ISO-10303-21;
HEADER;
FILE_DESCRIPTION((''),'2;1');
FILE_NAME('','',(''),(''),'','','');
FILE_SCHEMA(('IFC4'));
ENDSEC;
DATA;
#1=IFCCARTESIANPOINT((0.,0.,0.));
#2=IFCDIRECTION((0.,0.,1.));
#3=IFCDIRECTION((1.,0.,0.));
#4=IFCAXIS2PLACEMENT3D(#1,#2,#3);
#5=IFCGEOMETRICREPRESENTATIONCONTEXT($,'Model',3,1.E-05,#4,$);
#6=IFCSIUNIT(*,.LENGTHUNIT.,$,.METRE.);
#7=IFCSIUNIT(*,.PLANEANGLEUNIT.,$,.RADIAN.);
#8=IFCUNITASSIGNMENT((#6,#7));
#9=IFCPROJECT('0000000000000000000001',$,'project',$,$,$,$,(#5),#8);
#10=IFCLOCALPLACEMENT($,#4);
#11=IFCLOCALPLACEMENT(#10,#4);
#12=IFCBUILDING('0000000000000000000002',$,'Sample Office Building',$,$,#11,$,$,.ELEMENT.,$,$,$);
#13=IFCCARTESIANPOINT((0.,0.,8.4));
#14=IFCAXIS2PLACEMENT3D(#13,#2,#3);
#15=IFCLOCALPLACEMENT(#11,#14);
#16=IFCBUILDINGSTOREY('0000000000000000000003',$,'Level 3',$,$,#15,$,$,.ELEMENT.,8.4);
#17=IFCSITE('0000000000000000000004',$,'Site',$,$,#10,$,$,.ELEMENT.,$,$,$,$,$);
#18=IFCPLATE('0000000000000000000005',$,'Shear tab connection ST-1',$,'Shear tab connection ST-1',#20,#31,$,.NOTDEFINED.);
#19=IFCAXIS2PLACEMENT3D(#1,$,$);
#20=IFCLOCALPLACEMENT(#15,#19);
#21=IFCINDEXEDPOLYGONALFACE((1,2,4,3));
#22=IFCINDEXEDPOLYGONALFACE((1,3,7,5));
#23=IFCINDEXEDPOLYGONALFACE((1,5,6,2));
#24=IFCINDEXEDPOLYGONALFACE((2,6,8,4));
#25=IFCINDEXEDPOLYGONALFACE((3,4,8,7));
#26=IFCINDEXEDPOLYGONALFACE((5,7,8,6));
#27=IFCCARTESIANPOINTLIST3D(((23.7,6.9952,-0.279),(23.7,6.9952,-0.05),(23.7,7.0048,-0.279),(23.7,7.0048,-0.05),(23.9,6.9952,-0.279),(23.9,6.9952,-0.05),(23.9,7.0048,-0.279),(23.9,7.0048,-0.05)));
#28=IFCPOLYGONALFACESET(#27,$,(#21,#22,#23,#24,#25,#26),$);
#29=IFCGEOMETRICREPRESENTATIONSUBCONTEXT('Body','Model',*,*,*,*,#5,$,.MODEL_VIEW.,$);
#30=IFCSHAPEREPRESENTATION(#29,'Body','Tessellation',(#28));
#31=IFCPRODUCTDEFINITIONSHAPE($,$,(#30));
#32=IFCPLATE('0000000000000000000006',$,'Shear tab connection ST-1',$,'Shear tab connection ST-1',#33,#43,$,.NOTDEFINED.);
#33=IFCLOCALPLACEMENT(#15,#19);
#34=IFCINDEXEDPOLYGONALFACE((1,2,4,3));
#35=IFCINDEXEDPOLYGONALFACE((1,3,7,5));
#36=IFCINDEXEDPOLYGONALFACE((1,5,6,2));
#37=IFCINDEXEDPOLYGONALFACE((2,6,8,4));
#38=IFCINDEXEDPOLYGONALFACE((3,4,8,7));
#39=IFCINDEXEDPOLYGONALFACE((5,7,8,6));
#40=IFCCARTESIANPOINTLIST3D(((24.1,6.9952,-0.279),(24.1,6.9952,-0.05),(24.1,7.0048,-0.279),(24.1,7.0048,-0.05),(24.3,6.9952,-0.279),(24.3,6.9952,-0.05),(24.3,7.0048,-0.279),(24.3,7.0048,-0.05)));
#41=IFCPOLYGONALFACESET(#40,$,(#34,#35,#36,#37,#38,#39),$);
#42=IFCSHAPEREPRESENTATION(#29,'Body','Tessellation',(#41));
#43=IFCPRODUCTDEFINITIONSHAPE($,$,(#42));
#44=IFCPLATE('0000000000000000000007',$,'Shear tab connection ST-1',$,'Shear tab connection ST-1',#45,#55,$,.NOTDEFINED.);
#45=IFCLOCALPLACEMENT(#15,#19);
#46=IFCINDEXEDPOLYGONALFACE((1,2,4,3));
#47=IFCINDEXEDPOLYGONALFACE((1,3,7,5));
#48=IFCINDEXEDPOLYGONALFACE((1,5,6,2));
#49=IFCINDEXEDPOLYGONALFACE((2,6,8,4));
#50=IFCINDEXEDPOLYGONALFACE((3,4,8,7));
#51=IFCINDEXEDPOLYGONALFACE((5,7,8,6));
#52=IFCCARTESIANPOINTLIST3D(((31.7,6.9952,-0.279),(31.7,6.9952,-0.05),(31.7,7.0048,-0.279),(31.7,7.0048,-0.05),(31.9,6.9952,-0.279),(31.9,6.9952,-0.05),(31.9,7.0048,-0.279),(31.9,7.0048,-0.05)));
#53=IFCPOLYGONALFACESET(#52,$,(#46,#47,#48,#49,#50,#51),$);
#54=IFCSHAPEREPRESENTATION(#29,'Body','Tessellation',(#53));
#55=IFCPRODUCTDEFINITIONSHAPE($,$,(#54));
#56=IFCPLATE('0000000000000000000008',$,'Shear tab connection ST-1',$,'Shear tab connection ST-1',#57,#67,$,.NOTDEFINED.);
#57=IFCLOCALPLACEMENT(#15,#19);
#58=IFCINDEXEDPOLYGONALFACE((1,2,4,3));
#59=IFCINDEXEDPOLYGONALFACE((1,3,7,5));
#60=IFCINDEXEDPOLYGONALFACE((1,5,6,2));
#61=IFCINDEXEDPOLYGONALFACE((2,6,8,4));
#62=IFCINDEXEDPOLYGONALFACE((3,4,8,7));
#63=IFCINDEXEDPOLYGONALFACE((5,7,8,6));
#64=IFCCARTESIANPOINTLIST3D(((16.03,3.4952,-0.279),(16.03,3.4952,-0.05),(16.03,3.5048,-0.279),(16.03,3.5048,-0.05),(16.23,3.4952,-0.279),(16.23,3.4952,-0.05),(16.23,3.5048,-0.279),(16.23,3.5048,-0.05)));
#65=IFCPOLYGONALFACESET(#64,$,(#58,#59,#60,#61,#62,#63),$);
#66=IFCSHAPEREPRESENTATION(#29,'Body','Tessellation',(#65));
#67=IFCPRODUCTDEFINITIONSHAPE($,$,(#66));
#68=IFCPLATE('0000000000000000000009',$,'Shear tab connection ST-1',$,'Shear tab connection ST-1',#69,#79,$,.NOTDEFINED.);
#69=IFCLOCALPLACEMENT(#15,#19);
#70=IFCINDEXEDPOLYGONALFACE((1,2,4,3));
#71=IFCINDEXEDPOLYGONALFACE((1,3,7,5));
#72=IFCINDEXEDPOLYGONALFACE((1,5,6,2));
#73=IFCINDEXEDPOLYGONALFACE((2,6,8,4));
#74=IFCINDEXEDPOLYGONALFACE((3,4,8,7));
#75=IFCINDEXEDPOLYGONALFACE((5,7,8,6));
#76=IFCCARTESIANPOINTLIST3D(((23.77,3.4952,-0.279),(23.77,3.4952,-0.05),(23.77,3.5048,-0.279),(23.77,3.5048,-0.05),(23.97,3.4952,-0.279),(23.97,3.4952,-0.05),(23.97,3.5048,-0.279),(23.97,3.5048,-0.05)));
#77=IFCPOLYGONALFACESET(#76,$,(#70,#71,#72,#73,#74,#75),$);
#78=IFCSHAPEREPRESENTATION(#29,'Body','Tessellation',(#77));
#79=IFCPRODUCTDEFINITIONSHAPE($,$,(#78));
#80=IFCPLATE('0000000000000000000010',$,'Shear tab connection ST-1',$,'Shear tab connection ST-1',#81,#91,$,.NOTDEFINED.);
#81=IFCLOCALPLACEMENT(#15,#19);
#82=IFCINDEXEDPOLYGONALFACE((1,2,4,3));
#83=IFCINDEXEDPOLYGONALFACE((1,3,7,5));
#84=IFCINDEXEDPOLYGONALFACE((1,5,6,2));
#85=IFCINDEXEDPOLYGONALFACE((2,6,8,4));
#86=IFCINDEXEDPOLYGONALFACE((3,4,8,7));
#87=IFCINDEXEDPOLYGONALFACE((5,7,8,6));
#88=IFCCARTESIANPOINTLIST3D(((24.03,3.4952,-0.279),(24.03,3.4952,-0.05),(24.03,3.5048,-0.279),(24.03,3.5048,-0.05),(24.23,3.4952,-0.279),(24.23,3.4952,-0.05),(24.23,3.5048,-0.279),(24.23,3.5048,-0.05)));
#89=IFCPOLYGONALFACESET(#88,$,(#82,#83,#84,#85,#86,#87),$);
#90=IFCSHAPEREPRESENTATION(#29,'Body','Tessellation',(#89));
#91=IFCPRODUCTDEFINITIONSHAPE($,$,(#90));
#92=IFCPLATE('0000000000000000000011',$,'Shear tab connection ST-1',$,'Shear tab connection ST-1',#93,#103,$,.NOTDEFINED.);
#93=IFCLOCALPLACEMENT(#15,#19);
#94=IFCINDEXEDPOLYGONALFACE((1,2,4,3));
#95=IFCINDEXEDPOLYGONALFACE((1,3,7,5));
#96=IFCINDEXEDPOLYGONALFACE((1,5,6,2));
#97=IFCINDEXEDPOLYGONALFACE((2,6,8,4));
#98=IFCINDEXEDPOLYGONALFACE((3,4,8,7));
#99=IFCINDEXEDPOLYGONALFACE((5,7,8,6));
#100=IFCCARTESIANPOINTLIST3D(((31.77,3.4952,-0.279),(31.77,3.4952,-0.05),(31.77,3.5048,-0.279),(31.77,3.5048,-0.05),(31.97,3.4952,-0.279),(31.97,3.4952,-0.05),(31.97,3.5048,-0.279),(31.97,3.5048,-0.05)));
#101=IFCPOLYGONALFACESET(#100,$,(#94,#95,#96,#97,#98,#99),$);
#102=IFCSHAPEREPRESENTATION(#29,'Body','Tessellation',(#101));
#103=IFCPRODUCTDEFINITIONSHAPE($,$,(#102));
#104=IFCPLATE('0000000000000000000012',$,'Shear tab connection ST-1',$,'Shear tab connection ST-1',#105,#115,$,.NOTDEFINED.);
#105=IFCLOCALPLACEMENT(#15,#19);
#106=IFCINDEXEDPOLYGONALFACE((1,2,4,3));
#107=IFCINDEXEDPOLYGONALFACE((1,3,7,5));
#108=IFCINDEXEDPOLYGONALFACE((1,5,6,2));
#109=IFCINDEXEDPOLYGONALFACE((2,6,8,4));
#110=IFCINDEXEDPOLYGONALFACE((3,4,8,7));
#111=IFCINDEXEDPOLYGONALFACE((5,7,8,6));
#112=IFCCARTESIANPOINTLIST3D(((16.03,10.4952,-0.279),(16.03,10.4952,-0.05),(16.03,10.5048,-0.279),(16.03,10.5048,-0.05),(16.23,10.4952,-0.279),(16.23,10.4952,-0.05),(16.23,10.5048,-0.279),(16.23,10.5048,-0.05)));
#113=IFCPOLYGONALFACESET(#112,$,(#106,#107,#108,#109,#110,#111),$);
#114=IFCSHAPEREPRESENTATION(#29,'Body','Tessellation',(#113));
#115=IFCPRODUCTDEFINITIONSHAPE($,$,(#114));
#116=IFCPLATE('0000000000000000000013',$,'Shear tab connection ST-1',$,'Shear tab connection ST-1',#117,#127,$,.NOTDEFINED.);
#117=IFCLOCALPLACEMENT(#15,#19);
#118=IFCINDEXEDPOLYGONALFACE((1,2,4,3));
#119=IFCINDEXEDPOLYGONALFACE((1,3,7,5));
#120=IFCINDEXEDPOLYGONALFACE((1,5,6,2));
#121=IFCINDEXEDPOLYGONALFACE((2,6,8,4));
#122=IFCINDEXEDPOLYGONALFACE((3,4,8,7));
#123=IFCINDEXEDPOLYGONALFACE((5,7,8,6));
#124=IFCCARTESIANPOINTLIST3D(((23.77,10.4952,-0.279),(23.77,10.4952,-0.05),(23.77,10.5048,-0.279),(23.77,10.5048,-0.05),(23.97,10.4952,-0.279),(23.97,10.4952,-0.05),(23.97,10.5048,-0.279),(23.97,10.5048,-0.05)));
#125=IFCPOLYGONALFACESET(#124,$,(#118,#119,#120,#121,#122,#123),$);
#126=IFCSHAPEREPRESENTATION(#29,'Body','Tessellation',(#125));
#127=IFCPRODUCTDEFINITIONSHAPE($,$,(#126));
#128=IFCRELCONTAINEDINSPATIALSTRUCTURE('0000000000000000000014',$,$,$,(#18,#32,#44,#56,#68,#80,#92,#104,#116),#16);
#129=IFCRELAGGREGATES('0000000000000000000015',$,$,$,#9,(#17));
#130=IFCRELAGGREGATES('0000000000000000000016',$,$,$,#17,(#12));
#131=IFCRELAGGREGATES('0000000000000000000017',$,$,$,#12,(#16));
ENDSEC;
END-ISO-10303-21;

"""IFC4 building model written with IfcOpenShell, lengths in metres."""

from ifc_helpers import new_model, si_unit, frame, origin_with_axes, place, context, subcontext, project, spatial, rectangle, extrude, element, save


model = new_model("IFC4")

# Units and contexts
model_context = context("Model", 3, precision=1e-05, world=origin_with_axes())
body_context = subcontext(model_context, "Body", "Model", "MODEL_VIEW")
ifc_project = project(units=[si_unit("LENGTHUNIT", "METRE"), si_unit("PLANEANGLEUNIT", "RADIAN")], contexts=[model_context])

# Site, building, storey
site_placement = place(None, origin_with_axes())
site = spatial("IfcSite", under=ifc_project, at=site_placement, Name="Site", CompositionType="ELEMENT")
building_placement = place(site_placement, origin_with_axes())
building = spatial("IfcBuilding", under=site, at=building_placement, Name="Sample Office Building", CompositionType="ELEMENT")
storey_placement = place(building_placement, frame((0.0, 0.0, 8.4), z_axis=(0.0, 0.0, 1.0), x_axis=(1.0, 0.0, 0.0)))
storey = spatial("IfcBuildingStorey", under=building, at=storey_placement, Name="Level 3", CompositionType="ELEMENT", Elevation=8.4)

# Plates
for number, where, z_axis, x_axis, name in (
    (1, (23.8, 7.0, 8.121), (0.0, 0.0, 1.0), (1.0, 0.0, 0.0), "Shear tab connection ST-1"),
    (2, (24.2, 7.0, 8.121), (0.0, 0.0, 1.0), (1.0, 0.0, 0.0), "Shear tab connection ST-1"),
    (3, (31.8, 7.0, 8.121), (0.0, 0.0, 1.0), (1.0, 0.0, 0.0), "Shear tab connection ST-1"),
):
    element("IfcPlate", number, at=place(None, frame(where, z_axis=z_axis, x_axis=x_axis)), inside=storey, Name=name, ObjectType="Shear tab connection ST-1", PredefinedType="NOTDEFINED", context=body_context, shape_type="SweptSolid", body=[
        extrude(rectangle(XDim=0.2, YDim=0.0095), None, (0.0, 0.0, 1.0), 0.229),
    ])
for number, where, z_axis, x_axis, name in (
    (4, (16.13, 3.5, 8.121), (0.0, 0.0, 1.0), (1.0, 0.0, 0.0), "Shear tab connection ST-1"),
    (5, (23.87, 3.5, 8.121), (0.0, 0.0, 1.0), (1.0, 0.0, 0.0), "Shear tab connection ST-1"),
    (6, (24.13, 3.5, 8.121), (0.0, 0.0, 1.0), (1.0, 0.0, 0.0), "Shear tab connection ST-1"),
    (7, (31.87, 3.5, 8.121), (0.0, 0.0, 1.0), (1.0, 0.0, 0.0), "Shear tab connection ST-1"),
):
    element("IfcPlate", number, at=place(None, frame(where, z_axis=z_axis, x_axis=x_axis)), inside=storey, Name=name, ObjectType="Shear tab connection ST-1", PredefinedType="NOTDEFINED", context=body_context, shape_type="SweptSolid", body=[
        extrude(rectangle(XDim=0.2, YDim=0.0095), None, (0.0, 0.0, 1.0), 0.229),
    ])
for number, where, z_axis, x_axis, name in (
    (8, (16.13, 10.5, 8.121), (0.0, 0.0, 1.0), (1.0, 0.0, 0.0), "Shear tab connection ST-1"),
    (9, (23.87, 10.5, 8.121), (0.0, 0.0, 1.0), (1.0, 0.0, 0.0), "Shear tab connection ST-1"),
):
    element("IfcPlate", number, at=place(None, frame(where, z_axis=z_axis, x_axis=x_axis)), inside=storey, Name=name, ObjectType="Shear tab connection ST-1", PredefinedType="NOTDEFINED", context=body_context, shape_type="SweptSolid", body=[
        extrude(rectangle(XDim=0.2, YDim=0.0095), None, (0.0, 0.0, 1.0), 0.229),
    ])

save(model, "model.ifc")
